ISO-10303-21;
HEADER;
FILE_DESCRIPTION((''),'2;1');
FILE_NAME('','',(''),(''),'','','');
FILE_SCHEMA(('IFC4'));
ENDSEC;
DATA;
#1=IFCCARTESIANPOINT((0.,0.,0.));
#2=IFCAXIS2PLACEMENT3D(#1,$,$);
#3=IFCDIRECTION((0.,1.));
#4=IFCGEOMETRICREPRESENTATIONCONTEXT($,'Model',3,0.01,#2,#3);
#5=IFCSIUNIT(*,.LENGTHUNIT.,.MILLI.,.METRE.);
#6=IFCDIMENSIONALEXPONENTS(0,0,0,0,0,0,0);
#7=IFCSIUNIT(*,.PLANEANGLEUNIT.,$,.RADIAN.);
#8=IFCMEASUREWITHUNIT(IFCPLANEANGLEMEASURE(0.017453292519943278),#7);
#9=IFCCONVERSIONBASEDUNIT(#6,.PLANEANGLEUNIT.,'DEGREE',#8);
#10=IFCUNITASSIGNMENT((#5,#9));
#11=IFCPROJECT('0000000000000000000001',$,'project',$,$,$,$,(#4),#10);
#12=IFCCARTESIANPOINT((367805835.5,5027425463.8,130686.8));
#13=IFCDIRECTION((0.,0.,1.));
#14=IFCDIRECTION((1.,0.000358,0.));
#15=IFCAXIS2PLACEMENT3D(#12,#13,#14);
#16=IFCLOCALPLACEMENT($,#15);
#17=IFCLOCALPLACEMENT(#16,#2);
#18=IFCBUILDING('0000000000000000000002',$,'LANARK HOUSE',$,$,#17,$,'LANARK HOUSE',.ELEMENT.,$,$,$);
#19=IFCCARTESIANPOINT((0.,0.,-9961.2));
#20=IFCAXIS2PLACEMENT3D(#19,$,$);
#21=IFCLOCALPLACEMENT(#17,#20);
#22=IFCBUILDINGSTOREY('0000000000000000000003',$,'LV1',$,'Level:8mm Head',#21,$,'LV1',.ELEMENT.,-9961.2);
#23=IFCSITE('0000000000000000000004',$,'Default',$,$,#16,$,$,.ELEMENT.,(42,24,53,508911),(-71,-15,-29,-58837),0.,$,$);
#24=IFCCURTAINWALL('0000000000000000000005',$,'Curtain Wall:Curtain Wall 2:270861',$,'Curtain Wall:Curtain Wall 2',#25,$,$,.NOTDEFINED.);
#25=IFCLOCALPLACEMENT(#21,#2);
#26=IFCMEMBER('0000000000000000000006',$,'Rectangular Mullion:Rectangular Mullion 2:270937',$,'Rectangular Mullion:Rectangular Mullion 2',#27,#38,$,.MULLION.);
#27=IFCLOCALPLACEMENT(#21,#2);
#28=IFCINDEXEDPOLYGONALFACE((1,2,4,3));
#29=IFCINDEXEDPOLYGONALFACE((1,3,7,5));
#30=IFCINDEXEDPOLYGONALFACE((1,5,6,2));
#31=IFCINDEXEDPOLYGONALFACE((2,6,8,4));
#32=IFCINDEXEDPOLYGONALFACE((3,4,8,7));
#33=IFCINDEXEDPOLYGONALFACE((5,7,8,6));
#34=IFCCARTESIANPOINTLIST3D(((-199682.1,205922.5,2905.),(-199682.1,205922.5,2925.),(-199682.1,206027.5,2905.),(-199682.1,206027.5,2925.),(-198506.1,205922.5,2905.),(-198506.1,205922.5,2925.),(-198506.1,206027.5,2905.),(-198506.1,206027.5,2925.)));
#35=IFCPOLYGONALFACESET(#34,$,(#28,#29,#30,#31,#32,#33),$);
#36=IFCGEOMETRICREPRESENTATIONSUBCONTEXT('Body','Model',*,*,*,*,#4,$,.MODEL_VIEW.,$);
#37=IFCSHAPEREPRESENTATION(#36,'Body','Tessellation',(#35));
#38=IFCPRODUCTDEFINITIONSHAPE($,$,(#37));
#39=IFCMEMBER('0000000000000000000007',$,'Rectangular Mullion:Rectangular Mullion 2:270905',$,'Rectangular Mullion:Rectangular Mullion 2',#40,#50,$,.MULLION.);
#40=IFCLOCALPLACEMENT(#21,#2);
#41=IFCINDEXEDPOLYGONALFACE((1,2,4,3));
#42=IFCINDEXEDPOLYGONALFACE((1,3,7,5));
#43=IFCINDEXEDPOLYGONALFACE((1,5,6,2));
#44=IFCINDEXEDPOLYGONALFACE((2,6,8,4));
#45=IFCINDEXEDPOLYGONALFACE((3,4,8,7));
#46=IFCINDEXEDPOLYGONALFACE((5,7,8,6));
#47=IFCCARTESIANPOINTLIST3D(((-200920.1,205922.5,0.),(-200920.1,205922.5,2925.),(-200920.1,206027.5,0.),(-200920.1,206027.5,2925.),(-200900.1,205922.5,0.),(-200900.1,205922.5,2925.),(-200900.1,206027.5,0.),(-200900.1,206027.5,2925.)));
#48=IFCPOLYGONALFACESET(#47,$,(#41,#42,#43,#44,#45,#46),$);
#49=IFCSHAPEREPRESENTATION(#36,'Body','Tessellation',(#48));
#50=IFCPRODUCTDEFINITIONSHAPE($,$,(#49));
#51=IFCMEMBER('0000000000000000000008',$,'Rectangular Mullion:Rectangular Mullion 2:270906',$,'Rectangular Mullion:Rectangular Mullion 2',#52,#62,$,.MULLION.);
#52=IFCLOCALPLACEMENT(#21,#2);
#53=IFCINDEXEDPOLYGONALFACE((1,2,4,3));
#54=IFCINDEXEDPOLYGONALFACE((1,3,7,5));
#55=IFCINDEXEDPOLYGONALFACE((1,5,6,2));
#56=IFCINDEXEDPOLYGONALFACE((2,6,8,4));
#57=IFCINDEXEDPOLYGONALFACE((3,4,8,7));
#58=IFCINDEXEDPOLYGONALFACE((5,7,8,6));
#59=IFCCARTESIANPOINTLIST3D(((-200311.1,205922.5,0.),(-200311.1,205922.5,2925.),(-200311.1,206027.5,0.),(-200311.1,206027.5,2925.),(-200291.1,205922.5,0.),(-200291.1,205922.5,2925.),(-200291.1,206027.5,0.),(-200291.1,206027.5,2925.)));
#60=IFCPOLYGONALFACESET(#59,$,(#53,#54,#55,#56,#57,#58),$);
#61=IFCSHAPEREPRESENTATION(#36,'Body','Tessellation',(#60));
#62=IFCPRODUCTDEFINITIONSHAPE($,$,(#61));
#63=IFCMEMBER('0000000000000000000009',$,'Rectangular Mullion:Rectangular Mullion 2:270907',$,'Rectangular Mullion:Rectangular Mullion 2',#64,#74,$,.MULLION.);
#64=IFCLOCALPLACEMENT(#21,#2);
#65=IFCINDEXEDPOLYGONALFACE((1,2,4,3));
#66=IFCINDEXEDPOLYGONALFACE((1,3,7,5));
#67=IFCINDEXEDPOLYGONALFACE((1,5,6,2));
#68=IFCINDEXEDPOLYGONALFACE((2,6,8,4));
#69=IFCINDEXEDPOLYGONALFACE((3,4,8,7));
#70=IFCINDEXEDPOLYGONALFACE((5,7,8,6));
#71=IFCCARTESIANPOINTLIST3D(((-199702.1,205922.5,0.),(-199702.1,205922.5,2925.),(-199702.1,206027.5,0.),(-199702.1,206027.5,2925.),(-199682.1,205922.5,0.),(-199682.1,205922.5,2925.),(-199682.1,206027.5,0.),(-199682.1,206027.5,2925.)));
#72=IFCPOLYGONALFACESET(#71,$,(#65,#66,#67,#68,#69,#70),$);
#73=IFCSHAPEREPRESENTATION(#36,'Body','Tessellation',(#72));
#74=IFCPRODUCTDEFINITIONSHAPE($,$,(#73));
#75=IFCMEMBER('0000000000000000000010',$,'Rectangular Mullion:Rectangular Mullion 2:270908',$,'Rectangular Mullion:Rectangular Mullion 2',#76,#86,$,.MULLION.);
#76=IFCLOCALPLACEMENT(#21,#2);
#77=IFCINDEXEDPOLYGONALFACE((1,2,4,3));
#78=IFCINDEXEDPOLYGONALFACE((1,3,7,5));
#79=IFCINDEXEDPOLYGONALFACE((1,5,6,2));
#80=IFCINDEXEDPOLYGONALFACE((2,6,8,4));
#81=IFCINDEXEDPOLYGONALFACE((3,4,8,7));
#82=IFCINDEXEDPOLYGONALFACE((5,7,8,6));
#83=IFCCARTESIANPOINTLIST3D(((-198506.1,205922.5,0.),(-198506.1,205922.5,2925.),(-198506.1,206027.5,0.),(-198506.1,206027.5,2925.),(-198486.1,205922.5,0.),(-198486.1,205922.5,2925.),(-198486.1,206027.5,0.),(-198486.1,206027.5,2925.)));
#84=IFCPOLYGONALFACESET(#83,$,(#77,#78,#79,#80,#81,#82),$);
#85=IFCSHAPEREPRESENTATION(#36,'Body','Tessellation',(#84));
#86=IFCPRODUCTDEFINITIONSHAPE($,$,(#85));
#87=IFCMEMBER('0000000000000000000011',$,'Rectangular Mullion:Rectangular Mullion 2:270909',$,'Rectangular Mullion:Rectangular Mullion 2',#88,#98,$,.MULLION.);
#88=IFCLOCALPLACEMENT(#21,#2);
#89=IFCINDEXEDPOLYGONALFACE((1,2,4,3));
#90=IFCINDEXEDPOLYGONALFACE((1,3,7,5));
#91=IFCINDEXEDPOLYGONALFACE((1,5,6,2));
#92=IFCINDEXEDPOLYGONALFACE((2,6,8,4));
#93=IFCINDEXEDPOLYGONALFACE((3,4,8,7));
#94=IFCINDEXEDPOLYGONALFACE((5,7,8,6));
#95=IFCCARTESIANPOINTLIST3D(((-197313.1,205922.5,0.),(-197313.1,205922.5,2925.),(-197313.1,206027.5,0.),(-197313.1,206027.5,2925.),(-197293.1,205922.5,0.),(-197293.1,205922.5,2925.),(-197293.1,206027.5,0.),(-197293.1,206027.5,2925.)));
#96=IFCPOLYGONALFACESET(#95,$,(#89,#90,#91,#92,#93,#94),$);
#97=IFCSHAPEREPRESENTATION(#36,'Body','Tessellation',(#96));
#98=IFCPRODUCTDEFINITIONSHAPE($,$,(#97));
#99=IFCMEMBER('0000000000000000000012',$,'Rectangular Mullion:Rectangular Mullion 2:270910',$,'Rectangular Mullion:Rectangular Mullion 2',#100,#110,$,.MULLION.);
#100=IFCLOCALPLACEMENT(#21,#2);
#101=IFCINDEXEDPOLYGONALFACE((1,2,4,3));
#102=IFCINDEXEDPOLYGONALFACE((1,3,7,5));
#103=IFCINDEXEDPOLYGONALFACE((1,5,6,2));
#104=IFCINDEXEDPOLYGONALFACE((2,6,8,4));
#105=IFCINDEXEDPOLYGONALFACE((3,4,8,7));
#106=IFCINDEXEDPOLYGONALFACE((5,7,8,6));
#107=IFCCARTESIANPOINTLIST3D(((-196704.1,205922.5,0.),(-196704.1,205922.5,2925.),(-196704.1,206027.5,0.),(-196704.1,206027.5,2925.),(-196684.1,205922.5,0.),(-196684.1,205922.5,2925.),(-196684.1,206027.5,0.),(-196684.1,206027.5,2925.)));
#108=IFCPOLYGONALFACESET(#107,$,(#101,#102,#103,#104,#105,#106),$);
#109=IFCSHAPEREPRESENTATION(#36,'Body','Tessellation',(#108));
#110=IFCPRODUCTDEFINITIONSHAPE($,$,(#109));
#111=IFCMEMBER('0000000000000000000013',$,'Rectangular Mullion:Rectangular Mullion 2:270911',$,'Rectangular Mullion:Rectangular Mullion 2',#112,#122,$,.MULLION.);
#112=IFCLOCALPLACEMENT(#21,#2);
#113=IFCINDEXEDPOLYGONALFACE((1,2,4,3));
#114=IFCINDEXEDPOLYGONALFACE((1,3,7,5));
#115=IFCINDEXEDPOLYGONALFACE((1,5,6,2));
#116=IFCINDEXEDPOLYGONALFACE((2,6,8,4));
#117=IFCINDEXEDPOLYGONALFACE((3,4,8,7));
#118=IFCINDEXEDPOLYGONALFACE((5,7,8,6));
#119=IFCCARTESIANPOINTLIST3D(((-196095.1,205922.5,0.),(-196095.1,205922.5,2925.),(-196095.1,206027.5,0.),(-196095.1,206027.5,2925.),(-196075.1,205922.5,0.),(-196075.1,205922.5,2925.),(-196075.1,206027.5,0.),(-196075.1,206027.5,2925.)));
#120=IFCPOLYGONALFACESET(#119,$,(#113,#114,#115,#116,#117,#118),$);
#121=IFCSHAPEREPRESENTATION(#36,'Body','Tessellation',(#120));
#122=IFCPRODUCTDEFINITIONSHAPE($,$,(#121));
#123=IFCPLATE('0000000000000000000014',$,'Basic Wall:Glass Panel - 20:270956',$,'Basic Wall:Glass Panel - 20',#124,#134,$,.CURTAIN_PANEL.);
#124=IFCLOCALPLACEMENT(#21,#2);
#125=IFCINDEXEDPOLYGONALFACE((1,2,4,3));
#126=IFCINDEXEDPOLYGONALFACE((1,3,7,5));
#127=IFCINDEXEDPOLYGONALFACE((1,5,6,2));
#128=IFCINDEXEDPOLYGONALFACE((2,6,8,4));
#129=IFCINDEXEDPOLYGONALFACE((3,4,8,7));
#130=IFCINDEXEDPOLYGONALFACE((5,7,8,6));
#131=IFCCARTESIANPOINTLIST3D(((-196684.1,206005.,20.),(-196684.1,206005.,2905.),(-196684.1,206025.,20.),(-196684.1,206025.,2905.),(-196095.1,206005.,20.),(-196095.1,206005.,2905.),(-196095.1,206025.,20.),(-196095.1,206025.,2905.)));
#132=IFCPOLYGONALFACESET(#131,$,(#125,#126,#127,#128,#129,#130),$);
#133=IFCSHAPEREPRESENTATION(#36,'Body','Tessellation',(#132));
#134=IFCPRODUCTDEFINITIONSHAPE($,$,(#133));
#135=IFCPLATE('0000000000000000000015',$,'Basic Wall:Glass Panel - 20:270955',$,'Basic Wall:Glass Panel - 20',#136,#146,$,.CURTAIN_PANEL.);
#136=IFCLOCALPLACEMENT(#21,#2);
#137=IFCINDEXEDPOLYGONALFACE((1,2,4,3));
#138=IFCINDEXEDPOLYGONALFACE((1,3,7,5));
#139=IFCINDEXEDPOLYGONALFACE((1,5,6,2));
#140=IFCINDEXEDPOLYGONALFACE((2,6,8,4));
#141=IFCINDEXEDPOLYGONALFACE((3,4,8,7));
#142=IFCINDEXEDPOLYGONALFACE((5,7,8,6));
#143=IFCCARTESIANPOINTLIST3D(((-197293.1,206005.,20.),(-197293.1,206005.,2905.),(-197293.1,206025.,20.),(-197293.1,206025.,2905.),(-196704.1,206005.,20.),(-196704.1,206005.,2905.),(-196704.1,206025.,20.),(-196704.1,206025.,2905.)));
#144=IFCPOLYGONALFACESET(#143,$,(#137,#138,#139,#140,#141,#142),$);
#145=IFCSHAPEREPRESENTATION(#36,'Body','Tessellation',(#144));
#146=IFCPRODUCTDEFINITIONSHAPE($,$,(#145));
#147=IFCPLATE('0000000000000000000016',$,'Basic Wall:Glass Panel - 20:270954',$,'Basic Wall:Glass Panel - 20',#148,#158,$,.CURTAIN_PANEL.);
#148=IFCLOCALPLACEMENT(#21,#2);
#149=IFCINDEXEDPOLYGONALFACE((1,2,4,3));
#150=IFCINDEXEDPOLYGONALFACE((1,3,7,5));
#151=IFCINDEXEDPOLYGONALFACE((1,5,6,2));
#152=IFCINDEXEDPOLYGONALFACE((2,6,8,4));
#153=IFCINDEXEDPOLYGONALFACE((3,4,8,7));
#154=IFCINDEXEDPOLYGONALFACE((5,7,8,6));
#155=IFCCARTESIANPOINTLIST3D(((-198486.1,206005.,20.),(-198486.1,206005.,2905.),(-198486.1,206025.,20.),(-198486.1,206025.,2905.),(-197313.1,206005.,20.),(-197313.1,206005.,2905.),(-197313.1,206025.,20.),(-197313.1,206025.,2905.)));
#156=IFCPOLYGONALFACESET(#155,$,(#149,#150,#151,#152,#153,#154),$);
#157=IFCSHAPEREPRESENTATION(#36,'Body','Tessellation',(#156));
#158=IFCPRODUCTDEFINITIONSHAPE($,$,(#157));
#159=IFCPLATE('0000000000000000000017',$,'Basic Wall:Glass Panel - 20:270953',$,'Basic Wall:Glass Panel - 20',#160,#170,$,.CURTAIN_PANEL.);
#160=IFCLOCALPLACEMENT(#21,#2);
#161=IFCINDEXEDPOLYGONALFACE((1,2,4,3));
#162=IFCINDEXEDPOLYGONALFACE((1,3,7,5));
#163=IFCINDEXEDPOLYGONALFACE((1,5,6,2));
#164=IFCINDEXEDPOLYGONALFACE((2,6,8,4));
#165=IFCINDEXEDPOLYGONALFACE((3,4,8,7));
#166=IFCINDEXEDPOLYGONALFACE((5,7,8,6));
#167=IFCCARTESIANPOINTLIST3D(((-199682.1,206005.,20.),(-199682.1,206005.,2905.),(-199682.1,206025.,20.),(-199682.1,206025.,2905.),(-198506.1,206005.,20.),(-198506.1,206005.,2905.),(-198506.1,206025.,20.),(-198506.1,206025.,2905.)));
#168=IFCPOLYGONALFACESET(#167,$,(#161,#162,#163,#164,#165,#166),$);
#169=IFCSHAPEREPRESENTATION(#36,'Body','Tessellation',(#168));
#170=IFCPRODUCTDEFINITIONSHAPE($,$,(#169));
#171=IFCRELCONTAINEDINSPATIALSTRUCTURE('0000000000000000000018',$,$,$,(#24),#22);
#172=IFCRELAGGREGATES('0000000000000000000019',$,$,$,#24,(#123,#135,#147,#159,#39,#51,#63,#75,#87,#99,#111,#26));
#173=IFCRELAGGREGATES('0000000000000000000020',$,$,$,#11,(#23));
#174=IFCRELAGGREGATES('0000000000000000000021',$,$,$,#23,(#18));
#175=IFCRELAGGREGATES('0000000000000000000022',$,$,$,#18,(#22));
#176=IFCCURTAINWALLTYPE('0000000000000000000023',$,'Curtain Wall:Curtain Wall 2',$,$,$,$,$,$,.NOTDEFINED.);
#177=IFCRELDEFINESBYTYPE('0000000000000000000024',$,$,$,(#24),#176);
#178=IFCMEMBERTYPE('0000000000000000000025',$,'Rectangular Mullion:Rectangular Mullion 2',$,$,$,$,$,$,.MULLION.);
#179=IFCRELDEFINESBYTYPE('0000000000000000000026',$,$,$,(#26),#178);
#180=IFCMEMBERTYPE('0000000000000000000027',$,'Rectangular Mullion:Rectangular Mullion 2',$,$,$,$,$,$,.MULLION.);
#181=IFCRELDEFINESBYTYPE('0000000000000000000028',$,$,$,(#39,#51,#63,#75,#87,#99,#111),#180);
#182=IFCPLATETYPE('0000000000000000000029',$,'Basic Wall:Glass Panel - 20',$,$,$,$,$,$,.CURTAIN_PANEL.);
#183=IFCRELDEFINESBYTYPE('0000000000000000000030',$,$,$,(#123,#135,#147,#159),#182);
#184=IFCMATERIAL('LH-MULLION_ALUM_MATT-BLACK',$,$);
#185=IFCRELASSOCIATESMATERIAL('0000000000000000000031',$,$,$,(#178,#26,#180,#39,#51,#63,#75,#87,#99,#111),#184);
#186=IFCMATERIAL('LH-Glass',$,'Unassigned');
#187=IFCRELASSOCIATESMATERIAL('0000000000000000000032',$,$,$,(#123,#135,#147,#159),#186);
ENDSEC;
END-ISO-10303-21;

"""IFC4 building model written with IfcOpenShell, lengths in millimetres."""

from ifc_helpers import new_model, entity, si_unit, converted_unit, direction, frame, origin, place, context, subcontext, project, spatial, indexed_curve, outline, extrude, source, transform, mapped, material, type_object, type_shapes, element, aggregate, save


model = new_model("IFC4")

# Units and contexts
model_context = context("Model", 3, precision=0.01, world=origin(), true_north=direction((0.0, 1.0)))
body_context = subcontext(model_context, "Body", "Model", "MODEL_VIEW")
ifc_project = project(units=[si_unit("LENGTHUNIT", "METRE", prefix="MILLI"), converted_unit("PLANEANGLEUNIT", "DEGREE", entity("IfcPlaneAngleMeasure", 0.017453292519943278), si_unit("PLANEANGLEUNIT", "RADIAN"), dimensions=[0, 0, 0, 0, 0, 0, 0])], contexts=[model_context])

# Site, building, storey
site_placement = place(None, frame((367805835.5, 5027425463.8, 130686.8), z_axis=(0.0, 0.0, 1.0), x_axis=(1.0, 0.000358, 0.0)))
site = spatial("IfcSite", under=ifc_project, at=site_placement, Name="Default", CompositionType="ELEMENT", RefLatitude=(42, 24, 53, 508911), RefLongitude=(-71, -15, -29, -58837), RefElevation=0.0)
building_placement = place(site_placement, origin())
building = spatial("IfcBuilding", under=site, at=building_placement, Name="LANARK HOUSE", LongName="LANARK HOUSE", CompositionType="ELEMENT")
storey_placement = place(building_placement, frame((0.0, 0.0, -9961.2)))
storey = spatial("IfcBuildingStorey", under=building, at=storey_placement, Name="LV1", ObjectType="Level:8mm Head", LongName="LV1", CompositionType="ELEMENT", Elevation=-9961.2)

# Curtain wall, members, plates
curtain_wall_type = type_object("IfcCurtainWallType", Name="Curtain Wall:Curtain Wall 2", PredefinedType="NOTDEFINED")
curtain_wall_placement = place(storey_placement, frame((0.0, 0.0, 9961.2)))
curtain_wall = element("IfcCurtainWall", 1, at=curtain_wall_placement, inside=storey, type_object=curtain_wall_type, Name="Curtain Wall:Curtain Wall 2:270861", ObjectType="Curtain Wall:Curtain Wall 2", PredefinedType="NOTDEFINED")
ifc_material_1 = material(Name="LH-MULLION_ALUM_MATT-BLACK")
member_type_1 = type_object("IfcMemberType", Name="Rectangular Mullion:Rectangular Mullion 2", PredefinedType="MULLION", material=ifc_material_1)
shared_shape_1 = source(origin(), body_context, "Body", "SweptSolid", [
    extrude(outline(indexed_curve([(-10.0, -52.5), (10.0, -52.5), (10.0, 52.5), (-10.0, 52.5), (-10.0, -52.5)], self_intersect=False)), frame((-10.0, -40.0, -1176.0), z_axis=(0.0, 0.0, 1.0), x_axis=(-1.0, 0.0, 0.0)), (0.0, 0.0, 1.0), 1176.0),
])
type_shapes(member_type_1, [shared_shape_1])
member_1_placement = place(curtain_wall_placement, frame((-199682.1, 206015.0, -7036.2), z_axis=(-1.0, 0.0, 0.0), x_axis=(0.0, 0.0, 1.0)))
member_1 = element("IfcMember", 2, at=member_1_placement, type_object=member_type_1, material=ifc_material_1, Name="Rectangular Mullion:Rectangular Mullion 2:270937", ObjectType="Rectangular Mullion:Rectangular Mullion 2", PredefinedType="MULLION", context=body_context, shape_type="MappedRepresentation", body=[
    mapped(shared_shape_1, transform((0.0, 0.0, 0.0), scale=1.0)),
])
member_type_2 = type_object("IfcMemberType", Name="Rectangular Mullion:Rectangular Mullion 2", PredefinedType="MULLION", material=ifc_material_1)
shared_shape_2 = source(origin(), body_context, "Body", "SweptSolid", [
    extrude(outline(indexed_curve([(-10.0, -52.5), (10.0, -52.5), (10.0, 52.5), (-10.0, 52.5), (-10.0, -52.5)], self_intersect=False)), frame((0.0, -40.0, -2925.0), z_axis=(0.0, 0.0, 1.0), x_axis=(-1.0, 0.0, 0.0)), (0.0, 0.0, 1.0), 2925.0),
])
type_shapes(member_type_2, [shared_shape_2])
member_2_placement = place(curtain_wall_placement, frame((-200910.1, 206015.0, -9961.2), z_axis=(0.0, 0.0, -1.0), x_axis=(-1.0, 0.0, 0.0)))
member_2 = element("IfcMember", 3, at=member_2_placement, type_object=member_type_2, material=ifc_material_1, Name="Rectangular Mullion:Rectangular Mullion 2:270905", ObjectType="Rectangular Mullion:Rectangular Mullion 2", PredefinedType="MULLION", context=body_context, shape_type="MappedRepresentation", body=[
    mapped(shared_shape_2, transform((0.0, 0.0, 0.0), scale=1.0)),
])
member_3_placement = place(curtain_wall_placement, frame((-200301.1, 206015.0, -9961.2), z_axis=(0.0, 0.0, -1.0), x_axis=(-1.0, 0.0, 0.0)))
member_3 = element("IfcMember", 4, at=member_3_placement, type_object=member_type_2, material=ifc_material_1, Name="Rectangular Mullion:Rectangular Mullion 2:270906", ObjectType="Rectangular Mullion:Rectangular Mullion 2", PredefinedType="MULLION", context=body_context, shape_type="MappedRepresentation", body=[
    mapped(shared_shape_2, transform((0.0, 0.0, 0.0), scale=1.0)),
])
member_4_placement = place(curtain_wall_placement, frame((-199692.1, 206015.0, -9961.2), z_axis=(0.0, 0.0, -1.0), x_axis=(-1.0, 0.0, 0.0)))
member_4 = element("IfcMember", 5, at=member_4_placement, type_object=member_type_2, material=ifc_material_1, Name="Rectangular Mullion:Rectangular Mullion 2:270907", ObjectType="Rectangular Mullion:Rectangular Mullion 2", PredefinedType="MULLION", context=body_context, shape_type="MappedRepresentation", body=[
    mapped(shared_shape_2, transform((0.0, 0.0, 0.0), scale=1.0)),
])
member_5_placement = place(curtain_wall_placement, frame((-198496.1, 206015.0, -9961.2), z_axis=(0.0, 0.0, -1.0), x_axis=(-1.0, 0.0, 0.0)))
member_5 = element("IfcMember", 6, at=member_5_placement, type_object=member_type_2, material=ifc_material_1, Name="Rectangular Mullion:Rectangular Mullion 2:270908", ObjectType="Rectangular Mullion:Rectangular Mullion 2", PredefinedType="MULLION", context=body_context, shape_type="MappedRepresentation", body=[
    mapped(shared_shape_2, transform((0.0, 0.0, 0.0), scale=1.0)),
])
member_6_placement = place(curtain_wall_placement, frame((-197303.1, 206015.0, -9961.2), z_axis=(0.0, 0.0, -1.0), x_axis=(-1.0, 0.0, 0.0)))
member_6 = element("IfcMember", 7, at=member_6_placement, type_object=member_type_2, material=ifc_material_1, Name="Rectangular Mullion:Rectangular Mullion 2:270909", ObjectType="Rectangular Mullion:Rectangular Mullion 2", PredefinedType="MULLION", context=body_context, shape_type="MappedRepresentation", body=[
    mapped(shared_shape_2, transform((0.0, 0.0, 0.0), scale=1.0)),
])
member_7_placement = place(curtain_wall_placement, frame((-196694.1, 206015.0, -9961.2), z_axis=(0.0, 0.0, -1.0), x_axis=(-1.0, 0.0, 0.0)))
member_7 = element("IfcMember", 8, at=member_7_placement, type_object=member_type_2, material=ifc_material_1, Name="Rectangular Mullion:Rectangular Mullion 2:270910", ObjectType="Rectangular Mullion:Rectangular Mullion 2", PredefinedType="MULLION", context=body_context, shape_type="MappedRepresentation", body=[
    mapped(shared_shape_2, transform((0.0, 0.0, 0.0), scale=1.0)),
])
member_8_placement = place(curtain_wall_placement, frame((-196085.1, 206015.0, -9961.2), z_axis=(0.0, 0.0, -1.0), x_axis=(-1.0, 0.0, 0.0)))
member_8 = element("IfcMember", 9, at=member_8_placement, type_object=member_type_2, material=ifc_material_1, Name="Rectangular Mullion:Rectangular Mullion 2:270911", ObjectType="Rectangular Mullion:Rectangular Mullion 2", PredefinedType="MULLION", context=body_context, shape_type="MappedRepresentation", body=[
    mapped(shared_shape_2, transform((0.0, 0.0, 0.0), scale=1.0)),
])
ifc_material_2 = material(Name="LH-Glass", Category="Unassigned")
plate_type = type_object("IfcPlateType", Name="Basic Wall:Glass Panel - 20", PredefinedType="CURTAIN_PANEL")
plate_1_placement = place(storey_placement, frame((-196095.1, 206015.0, 20.0), z_axis=(0.0, 0.0, 1.0), x_axis=(-1.0, 0.0, 0.0)))
plate_1 = element("IfcPlate", 10, at=plate_1_placement, type_object=plate_type, material=ifc_material_2, Name="Basic Wall:Glass Panel - 20:270956", ObjectType="Basic Wall:Glass Panel - 20", PredefinedType="CURTAIN_PANEL", context=body_context, shape_type="SweptSolid", body=[
    extrude(outline(indexed_curve([(-10.0, -294.5), (10.0, -294.5), (10.0, 294.5), (-10.0, 294.5), (-10.0, -294.5)], self_intersect=False)), frame((294.5, 0.0, 0.0), z_axis=(0.0, 0.0, 1.0), x_axis=(0.0, 1.0, 0.0)), (0.0, 0.0, 1.0), 2885.0),
])
plate_2_placement = place(storey_placement, frame((-196704.1, 206015.0, 20.0), z_axis=(0.0, 0.0, 1.0), x_axis=(-1.0, 0.0, 0.0)))
plate_2 = element("IfcPlate", 11, at=plate_2_placement, type_object=plate_type, material=ifc_material_2, Name="Basic Wall:Glass Panel - 20:270955", ObjectType="Basic Wall:Glass Panel - 20", PredefinedType="CURTAIN_PANEL", context=body_context, shape_type="SweptSolid", body=[
    extrude(outline(indexed_curve([(-10.0, -294.5), (10.0, -294.5), (10.0, 294.5), (-10.0, 294.5), (-10.0, -294.5)], self_intersect=False)), frame((294.5, 0.0, 0.0), z_axis=(0.0, 0.0, 1.0), x_axis=(0.0, 1.0, 0.0)), (0.0, 0.0, 1.0), 2885.0),
])
plate_3_placement = place(storey_placement, frame((-197313.1, 206015.0, 20.0), z_axis=(0.0, 0.0, 1.0), x_axis=(-1.0, 0.0, 0.0)))
plate_3 = element("IfcPlate", 12, at=plate_3_placement, type_object=plate_type, material=ifc_material_2, Name="Basic Wall:Glass Panel - 20:270954", ObjectType="Basic Wall:Glass Panel - 20", PredefinedType="CURTAIN_PANEL", context=body_context, shape_type="SweptSolid", body=[
    extrude(outline(indexed_curve([(-10.0, -586.5), (10.0, -586.5), (10.0, 586.5), (-10.0, 586.5), (-10.0, -586.5)], self_intersect=False)), frame((586.5, 0.0, 0.0), z_axis=(0.0, 0.0, 1.0), x_axis=(0.0, 1.0, 0.0)), (0.0, 0.0, 1.0), 2885.0),
])
plate_4_placement = place(storey_placement, frame((-198506.1, 206015.0, 20.0), z_axis=(0.0, 0.0, 1.0), x_axis=(-1.0, 0.0, 0.0)))
plate_4 = element("IfcPlate", 13, at=plate_4_placement, type_object=plate_type, material=ifc_material_2, Name="Basic Wall:Glass Panel - 20:270953", ObjectType="Basic Wall:Glass Panel - 20", PredefinedType="CURTAIN_PANEL", context=body_context, shape_type="SweptSolid", body=[
    extrude(outline(indexed_curve([(-10.0, -588.0), (10.0, -588.0), (10.0, 588.0), (-10.0, 588.0), (-10.0, -588.0)], self_intersect=False)), frame((588.0, 0.0, 0.0), z_axis=(0.0, 0.0, 1.0), x_axis=(0.0, 1.0, 0.0)), (0.0, 0.0, 1.0), 2885.0),
])
aggregate(curtain_wall, [plate_1, plate_2, plate_3, plate_4, member_2, member_3, member_4, member_5, member_6, member_7, member_8, member_1])

save(model, "model.ifc")
